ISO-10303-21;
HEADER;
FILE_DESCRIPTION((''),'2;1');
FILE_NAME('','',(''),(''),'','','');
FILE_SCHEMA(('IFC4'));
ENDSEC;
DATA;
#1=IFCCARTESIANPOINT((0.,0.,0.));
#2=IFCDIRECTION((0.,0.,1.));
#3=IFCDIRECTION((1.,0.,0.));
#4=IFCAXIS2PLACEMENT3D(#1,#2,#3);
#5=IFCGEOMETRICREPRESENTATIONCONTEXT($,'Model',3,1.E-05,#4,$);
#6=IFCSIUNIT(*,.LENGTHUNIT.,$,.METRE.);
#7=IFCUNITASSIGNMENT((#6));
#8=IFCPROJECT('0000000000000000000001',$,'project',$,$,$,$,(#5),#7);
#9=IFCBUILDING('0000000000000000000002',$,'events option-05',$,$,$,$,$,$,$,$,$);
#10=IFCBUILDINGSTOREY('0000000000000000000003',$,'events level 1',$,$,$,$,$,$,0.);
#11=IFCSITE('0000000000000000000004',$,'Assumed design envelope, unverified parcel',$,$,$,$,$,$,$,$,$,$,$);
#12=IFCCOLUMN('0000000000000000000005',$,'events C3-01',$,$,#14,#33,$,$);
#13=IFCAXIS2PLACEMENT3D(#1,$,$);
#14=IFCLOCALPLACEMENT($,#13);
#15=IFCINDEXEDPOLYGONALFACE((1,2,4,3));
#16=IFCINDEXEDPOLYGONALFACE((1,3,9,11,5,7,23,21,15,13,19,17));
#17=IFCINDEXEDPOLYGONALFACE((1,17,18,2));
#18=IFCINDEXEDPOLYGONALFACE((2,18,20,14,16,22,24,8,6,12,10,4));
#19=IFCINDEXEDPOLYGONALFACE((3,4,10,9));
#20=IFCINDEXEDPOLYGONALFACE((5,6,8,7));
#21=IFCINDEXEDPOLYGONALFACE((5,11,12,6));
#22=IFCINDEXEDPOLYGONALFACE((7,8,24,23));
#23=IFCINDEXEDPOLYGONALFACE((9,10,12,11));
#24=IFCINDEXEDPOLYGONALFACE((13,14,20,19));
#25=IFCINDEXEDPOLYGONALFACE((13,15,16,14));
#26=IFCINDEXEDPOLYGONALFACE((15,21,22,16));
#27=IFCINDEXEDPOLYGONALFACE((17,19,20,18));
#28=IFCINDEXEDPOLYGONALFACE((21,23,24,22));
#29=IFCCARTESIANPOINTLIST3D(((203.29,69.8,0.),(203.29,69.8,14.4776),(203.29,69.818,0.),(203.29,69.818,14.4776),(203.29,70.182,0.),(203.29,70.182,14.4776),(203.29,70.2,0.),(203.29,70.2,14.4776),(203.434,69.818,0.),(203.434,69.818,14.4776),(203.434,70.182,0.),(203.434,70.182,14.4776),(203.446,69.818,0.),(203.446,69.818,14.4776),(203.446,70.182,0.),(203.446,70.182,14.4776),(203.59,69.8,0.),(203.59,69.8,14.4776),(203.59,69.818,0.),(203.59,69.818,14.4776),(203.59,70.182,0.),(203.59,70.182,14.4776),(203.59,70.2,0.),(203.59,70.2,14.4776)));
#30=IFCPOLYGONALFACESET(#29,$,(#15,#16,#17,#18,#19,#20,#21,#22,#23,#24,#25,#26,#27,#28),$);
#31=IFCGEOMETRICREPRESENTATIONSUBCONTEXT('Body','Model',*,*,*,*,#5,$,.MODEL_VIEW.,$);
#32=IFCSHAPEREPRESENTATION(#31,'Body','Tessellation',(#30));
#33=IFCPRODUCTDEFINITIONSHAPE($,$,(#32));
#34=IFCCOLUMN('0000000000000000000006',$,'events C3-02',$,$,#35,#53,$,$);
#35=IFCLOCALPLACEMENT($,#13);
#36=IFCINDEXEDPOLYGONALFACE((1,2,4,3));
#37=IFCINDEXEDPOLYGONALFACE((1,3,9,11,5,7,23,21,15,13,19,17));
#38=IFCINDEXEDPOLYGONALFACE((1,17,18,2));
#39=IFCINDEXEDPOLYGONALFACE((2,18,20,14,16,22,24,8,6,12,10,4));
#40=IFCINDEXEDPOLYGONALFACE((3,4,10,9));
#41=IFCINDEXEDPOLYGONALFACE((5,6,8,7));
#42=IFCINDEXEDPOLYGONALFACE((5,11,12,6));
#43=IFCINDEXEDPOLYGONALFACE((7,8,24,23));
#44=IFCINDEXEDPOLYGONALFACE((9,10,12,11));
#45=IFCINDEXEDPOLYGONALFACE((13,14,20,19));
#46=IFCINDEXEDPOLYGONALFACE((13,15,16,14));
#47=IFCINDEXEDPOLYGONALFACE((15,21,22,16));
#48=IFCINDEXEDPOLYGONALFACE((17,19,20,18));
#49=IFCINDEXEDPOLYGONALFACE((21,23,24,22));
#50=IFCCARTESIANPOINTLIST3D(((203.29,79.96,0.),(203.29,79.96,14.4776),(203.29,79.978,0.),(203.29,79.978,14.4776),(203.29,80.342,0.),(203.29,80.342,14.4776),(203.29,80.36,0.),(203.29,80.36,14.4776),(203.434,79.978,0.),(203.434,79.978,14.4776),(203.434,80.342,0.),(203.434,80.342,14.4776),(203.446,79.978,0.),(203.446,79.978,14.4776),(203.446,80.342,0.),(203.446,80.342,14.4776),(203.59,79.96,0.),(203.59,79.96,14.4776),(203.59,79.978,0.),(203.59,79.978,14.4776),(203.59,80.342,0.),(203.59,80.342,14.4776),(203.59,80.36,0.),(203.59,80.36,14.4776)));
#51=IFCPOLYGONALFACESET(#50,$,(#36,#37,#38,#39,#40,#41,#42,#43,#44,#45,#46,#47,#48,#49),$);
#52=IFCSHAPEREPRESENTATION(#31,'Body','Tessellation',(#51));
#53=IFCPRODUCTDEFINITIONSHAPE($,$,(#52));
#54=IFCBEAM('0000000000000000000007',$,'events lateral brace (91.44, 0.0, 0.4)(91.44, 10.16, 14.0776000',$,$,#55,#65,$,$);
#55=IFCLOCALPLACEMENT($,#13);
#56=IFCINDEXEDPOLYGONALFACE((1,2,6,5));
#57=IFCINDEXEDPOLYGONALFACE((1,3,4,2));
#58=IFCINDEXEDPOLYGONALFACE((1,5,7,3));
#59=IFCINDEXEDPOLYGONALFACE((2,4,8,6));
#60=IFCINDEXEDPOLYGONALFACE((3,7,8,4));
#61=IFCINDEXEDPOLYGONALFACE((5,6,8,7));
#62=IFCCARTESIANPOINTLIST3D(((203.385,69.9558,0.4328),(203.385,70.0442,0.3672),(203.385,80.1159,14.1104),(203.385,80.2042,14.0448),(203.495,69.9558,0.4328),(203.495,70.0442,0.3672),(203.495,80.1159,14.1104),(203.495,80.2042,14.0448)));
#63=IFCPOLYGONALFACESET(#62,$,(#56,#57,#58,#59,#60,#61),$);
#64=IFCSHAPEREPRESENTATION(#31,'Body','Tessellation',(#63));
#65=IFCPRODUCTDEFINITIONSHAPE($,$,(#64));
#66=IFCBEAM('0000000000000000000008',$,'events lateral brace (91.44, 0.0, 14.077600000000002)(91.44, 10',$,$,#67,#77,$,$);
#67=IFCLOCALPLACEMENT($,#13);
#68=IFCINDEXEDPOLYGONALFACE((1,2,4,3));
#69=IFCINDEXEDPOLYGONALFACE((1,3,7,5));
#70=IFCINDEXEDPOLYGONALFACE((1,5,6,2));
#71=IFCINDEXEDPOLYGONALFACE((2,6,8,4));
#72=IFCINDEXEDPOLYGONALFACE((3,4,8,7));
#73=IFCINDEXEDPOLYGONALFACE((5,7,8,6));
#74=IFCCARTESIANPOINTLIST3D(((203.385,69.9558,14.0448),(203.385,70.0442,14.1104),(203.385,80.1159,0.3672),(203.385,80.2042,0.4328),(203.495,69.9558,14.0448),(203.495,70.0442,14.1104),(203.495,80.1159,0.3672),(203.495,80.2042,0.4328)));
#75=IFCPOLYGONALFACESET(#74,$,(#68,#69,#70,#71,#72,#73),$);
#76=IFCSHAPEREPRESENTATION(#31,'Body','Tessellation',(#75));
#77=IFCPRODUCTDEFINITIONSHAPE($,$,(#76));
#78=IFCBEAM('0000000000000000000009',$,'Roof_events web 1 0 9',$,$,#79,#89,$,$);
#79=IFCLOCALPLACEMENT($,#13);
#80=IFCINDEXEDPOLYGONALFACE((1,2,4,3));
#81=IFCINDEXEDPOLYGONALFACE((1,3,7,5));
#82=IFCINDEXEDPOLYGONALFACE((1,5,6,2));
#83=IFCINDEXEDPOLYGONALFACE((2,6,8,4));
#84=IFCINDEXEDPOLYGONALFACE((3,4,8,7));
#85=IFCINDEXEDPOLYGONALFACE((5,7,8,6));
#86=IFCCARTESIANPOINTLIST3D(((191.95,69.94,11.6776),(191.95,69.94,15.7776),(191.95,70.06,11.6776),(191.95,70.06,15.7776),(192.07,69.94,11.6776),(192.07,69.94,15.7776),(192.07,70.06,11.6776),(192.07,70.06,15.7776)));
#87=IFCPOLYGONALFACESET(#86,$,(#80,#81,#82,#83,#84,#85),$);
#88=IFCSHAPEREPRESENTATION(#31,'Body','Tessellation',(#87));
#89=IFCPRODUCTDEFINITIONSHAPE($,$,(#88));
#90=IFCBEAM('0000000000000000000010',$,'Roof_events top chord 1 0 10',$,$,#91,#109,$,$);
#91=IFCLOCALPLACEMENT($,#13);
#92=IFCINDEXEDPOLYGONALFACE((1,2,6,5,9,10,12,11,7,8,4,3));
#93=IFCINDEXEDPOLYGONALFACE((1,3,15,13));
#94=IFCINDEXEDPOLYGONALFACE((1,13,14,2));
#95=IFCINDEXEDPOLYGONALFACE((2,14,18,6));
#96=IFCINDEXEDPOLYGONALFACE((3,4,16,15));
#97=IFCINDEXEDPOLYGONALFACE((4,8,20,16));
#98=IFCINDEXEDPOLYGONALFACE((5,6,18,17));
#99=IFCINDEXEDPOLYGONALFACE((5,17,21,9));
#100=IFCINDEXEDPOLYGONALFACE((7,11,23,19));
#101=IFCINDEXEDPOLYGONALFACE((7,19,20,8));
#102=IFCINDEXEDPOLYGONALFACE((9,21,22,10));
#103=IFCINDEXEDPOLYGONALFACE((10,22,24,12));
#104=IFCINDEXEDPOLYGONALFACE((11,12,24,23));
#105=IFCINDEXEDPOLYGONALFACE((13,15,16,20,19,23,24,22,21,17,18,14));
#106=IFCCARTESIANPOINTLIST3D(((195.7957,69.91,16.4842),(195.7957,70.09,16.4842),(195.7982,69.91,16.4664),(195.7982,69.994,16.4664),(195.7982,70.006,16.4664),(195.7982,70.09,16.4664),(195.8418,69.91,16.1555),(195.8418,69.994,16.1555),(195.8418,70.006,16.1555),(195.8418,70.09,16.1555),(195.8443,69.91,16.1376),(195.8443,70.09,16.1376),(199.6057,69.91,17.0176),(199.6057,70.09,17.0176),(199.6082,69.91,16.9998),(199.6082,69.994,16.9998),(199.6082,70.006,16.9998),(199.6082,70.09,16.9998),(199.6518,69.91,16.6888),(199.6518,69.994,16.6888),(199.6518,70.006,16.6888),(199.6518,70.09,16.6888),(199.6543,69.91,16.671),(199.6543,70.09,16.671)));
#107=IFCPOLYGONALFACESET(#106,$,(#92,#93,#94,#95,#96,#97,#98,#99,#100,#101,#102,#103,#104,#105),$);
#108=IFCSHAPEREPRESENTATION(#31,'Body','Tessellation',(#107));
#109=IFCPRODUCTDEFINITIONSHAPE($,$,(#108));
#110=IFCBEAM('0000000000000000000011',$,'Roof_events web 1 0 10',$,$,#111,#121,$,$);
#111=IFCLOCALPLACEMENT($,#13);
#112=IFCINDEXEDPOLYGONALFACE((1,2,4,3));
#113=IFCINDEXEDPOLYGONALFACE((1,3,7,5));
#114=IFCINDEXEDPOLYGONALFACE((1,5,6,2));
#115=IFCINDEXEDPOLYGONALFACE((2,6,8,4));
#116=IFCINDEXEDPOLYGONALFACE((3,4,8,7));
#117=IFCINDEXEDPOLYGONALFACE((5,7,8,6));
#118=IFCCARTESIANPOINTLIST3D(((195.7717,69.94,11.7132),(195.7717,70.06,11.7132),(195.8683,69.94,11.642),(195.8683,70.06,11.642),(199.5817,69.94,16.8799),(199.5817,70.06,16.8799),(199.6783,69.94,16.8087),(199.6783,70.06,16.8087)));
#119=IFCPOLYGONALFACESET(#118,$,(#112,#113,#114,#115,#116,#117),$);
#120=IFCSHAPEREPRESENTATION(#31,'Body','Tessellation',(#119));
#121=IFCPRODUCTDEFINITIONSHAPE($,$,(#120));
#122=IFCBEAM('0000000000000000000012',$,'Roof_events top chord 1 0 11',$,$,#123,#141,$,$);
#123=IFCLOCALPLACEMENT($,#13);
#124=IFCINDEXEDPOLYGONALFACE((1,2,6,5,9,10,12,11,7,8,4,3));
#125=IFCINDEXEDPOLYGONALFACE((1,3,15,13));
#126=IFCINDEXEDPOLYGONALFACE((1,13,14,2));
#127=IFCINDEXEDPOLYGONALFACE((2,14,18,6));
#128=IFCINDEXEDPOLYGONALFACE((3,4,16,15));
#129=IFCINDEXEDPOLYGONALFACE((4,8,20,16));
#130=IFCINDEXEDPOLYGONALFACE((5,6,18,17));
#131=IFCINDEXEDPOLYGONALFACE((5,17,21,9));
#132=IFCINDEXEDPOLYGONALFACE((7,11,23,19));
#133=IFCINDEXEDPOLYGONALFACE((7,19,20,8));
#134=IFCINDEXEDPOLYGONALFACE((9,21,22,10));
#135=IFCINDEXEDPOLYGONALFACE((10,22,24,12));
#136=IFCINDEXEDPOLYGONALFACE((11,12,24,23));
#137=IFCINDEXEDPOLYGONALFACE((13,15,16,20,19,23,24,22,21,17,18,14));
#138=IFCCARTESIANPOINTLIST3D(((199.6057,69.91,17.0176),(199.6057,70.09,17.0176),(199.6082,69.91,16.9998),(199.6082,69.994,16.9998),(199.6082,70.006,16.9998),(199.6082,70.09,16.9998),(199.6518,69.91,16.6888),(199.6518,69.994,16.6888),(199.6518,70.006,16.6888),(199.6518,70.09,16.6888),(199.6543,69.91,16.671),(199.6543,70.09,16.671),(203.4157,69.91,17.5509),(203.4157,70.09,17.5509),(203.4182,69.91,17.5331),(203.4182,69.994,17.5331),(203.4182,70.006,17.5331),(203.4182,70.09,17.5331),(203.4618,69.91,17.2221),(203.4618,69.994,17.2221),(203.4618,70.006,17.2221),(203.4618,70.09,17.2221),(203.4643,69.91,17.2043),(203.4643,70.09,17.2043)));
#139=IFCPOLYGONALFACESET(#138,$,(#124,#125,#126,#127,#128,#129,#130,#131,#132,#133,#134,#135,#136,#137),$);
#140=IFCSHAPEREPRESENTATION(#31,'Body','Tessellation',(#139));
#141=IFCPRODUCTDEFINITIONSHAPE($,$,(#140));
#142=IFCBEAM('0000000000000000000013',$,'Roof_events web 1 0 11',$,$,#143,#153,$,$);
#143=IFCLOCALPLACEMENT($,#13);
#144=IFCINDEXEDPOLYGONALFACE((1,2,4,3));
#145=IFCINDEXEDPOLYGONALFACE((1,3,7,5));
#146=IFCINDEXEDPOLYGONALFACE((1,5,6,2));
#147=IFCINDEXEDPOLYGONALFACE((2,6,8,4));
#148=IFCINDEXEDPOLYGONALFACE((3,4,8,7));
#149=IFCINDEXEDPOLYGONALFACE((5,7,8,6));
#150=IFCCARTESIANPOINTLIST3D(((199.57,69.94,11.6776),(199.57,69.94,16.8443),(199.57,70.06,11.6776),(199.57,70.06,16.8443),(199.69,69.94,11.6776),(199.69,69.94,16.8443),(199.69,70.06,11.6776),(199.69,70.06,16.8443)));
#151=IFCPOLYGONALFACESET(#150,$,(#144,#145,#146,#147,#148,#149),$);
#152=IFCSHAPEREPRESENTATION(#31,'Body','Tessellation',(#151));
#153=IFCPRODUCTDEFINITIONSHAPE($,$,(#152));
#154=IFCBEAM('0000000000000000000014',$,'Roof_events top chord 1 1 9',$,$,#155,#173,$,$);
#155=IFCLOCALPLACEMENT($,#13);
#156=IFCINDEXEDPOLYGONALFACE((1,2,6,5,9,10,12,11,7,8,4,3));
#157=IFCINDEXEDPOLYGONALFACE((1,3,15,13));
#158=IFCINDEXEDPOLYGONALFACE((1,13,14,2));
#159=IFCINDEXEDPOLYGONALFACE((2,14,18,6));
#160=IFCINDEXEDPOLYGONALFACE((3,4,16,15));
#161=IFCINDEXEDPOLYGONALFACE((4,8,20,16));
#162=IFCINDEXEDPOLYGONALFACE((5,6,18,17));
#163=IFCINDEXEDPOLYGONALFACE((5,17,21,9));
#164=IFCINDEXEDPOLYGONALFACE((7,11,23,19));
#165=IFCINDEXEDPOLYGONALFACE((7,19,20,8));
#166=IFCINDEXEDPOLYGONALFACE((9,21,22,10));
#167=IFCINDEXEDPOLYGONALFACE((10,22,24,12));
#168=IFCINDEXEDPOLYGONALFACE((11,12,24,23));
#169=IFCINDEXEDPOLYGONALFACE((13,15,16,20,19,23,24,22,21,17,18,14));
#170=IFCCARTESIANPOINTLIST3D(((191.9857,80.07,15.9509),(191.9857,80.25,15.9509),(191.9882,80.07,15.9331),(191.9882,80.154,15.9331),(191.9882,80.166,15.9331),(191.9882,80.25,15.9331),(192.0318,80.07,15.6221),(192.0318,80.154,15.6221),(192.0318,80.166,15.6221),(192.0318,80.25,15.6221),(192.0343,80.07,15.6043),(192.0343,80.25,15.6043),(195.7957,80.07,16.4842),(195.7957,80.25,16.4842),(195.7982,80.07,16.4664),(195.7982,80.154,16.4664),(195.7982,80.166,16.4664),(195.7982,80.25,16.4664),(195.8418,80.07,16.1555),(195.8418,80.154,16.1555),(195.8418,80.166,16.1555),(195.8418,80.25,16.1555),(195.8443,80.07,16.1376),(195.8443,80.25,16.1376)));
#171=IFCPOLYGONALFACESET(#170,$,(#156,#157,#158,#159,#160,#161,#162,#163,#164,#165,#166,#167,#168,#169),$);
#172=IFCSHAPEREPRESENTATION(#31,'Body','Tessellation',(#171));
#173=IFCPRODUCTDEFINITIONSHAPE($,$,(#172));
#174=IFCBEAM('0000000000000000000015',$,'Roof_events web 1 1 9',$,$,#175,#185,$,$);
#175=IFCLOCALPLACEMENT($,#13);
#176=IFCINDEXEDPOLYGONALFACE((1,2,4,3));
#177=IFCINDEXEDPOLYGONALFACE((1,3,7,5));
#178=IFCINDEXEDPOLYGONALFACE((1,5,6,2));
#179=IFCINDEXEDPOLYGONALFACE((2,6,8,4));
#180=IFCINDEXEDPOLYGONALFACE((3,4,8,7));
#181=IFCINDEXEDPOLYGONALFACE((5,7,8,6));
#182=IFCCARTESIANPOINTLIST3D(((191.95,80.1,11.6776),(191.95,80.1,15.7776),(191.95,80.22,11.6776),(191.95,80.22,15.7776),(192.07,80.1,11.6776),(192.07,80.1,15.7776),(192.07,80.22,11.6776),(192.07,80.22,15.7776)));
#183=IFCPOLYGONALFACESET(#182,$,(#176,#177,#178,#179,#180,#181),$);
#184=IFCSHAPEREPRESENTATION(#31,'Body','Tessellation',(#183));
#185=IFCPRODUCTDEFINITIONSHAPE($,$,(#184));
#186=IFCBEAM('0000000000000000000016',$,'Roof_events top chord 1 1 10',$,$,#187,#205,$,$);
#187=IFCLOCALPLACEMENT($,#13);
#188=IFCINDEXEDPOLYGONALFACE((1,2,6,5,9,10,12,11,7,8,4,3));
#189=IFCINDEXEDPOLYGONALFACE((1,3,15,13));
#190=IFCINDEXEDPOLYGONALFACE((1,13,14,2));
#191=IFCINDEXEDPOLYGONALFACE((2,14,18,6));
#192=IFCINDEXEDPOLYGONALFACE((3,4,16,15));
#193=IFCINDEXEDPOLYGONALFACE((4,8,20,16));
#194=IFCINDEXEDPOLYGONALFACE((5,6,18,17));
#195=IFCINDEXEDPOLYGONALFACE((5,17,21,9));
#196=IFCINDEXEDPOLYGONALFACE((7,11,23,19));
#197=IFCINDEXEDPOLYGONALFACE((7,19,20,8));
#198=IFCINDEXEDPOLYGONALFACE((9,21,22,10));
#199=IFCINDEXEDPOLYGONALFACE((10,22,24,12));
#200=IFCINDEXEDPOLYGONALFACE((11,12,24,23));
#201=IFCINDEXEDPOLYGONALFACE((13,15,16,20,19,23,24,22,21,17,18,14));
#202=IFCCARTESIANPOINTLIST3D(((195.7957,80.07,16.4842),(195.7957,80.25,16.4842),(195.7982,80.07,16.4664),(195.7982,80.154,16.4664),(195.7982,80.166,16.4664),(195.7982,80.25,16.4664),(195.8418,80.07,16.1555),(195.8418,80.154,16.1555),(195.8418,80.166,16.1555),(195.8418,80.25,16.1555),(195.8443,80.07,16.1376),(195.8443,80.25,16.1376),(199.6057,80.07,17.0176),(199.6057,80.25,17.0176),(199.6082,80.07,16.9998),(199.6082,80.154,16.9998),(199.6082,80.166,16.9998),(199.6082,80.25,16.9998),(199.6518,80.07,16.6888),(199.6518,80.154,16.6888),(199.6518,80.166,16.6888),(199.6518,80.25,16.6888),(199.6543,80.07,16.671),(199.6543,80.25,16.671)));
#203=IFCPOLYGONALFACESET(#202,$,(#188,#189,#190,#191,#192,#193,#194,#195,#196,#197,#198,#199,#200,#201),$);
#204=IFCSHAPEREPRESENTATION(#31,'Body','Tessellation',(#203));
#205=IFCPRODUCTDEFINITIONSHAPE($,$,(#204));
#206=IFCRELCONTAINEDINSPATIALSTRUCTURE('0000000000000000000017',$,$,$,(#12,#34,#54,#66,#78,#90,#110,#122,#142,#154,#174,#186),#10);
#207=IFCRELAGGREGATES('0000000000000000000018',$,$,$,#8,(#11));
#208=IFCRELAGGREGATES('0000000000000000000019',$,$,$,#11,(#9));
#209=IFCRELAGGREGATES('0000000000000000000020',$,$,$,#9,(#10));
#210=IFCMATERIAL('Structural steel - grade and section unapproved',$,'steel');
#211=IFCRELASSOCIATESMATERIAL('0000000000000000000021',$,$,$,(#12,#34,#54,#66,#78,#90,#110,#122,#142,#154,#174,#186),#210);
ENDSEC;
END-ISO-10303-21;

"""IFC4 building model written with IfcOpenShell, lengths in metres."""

from ifc_helpers import new_model, si_unit, frame, origin_with_axes, place, context, subcontext, project, spatial, rectangle, i_section, extrude, material, element, save


model = new_model("IFC4")

# Units and contexts
model_context = context("Model", 3, precision=1e-05, world=origin_with_axes())
body_context = subcontext(model_context, "Body", "Model", "MODEL_VIEW")
ifc_project = project(units=[si_unit("LENGTHUNIT", "METRE")], contexts=[model_context])

# Site, building, storey
site = spatial("IfcSite", under=ifc_project, Name="Assumed design envelope, unverified parcel")
building = spatial("IfcBuilding", under=site, Name="events option-05")
storey = spatial("IfcBuildingStorey", under=building, Name="events level 1", Elevation=0.0)

# Columns
ifc_material_1 = material(Name="Structural steel - grade and section unapproved", Category="steel")
for number, where, z_axis, x_axis, name in (
    (1, (203.44, 70.0, 0.0), (0.0, 0.0, 1.0), (-1.0, 0.0, 0.0), "events C3-01"),
    (2, (203.44, 80.16, 0.0), (0.0, 0.0, 1.0), (-1.0, 0.0, 0.0), "events C3-02"),
):
    element("IfcColumn", number, at=place(None, frame(where, z_axis=z_axis, x_axis=x_axis)), inside=storey, material=ifc_material_1, Name=name, context=body_context, shape_type="SweptSolid", body=[
        extrude(i_section(OverallWidth=0.3, OverallDepth=0.4, WebThickness=0.012, FlangeThickness=0.018, FilletRadius=0.0), origin_with_axes(), (0.0, 0.0, 1.0), 14.4776),
    ])

# Beams
for number, where, z_axis, x_axis, name in (
    (3, (203.44, 70.0, 0.4), (0.0, 0.596305, 0.802758), (-1.0, 0.0, 0.0), "events lateral brace (91.44, 0.0, 0.4)(91.44, 10.16, 14.0776000"),
    (4, (203.44, 70.0, 14.0776), (0.0, 0.596305, -0.802758), (-1.0, 0.0, 0.0), "events lateral brace (91.44, 0.0, 14.077600000000002)(91.44, 10"),
):
    element("IfcBeam", number, at=place(None, frame(where, z_axis=z_axis, x_axis=x_axis)), inside=storey, material=ifc_material_1, Name=name, context=body_context, shape_type="SweptSolid", body=[
        extrude(rectangle(XDim=0.11, YDim=0.11), origin_with_axes(), (0.0, 0.0, 1.0), 17.0383),
    ])
beam_1_placement = place(None, frame((192.01, 70.0, 11.6776), z_axis=(0.0, 0.0, 1.0), x_axis=(-1.0, 0.0, 0.0)))
element("IfcBeam", 5, at=beam_1_placement, inside=storey, material=ifc_material_1, Name="Roof_events web 1 0 9", context=body_context, shape_type="SweptSolid", body=[
    extrude(rectangle(XDim=0.12, YDim=0.12), origin_with_axes(), (0.0, 0.0, 1.0), 4.1),
])
beam_2_placement = place(None, frame((195.82, 70.0, 16.3109), z_axis=(0.990344, 0.0, 0.138631), x_axis=(0.0, 1.0, 0.0)))
element("IfcBeam", 6, at=beam_2_placement, inside=storey, material=ifc_material_1, Name="Roof_events top chord 1 0 10", context=body_context, shape_type="SweptSolid", body=[
    extrude(i_section(OverallWidth=0.18, OverallDepth=0.35, WebThickness=0.012, FlangeThickness=0.018, FilletRadius=0.0), origin_with_axes(), (0.0, 0.0, 1.0), 3.8471),
])
beam_3_placement = place(None, frame((195.82, 70.0, 11.6776), z_axis=(0.5935, 0.0, 0.804834), x_axis=(0.0, 1.0, 0.0)))
element("IfcBeam", 7, at=beam_3_placement, inside=storey, material=ifc_material_1, Name="Roof_events web 1 0 10", context=body_context, shape_type="SweptSolid", body=[
    extrude(rectangle(XDim=0.12, YDim=0.12), origin_with_axes(), (0.0, 0.0, 1.0), 6.4195),
])
beam_4_placement = place(None, frame((199.63, 70.0, 16.8443), z_axis=(0.990344, 0.0, 0.138631), x_axis=(0.0, 1.0, 0.0)))
element("IfcBeam", 8, at=beam_4_placement, inside=storey, material=ifc_material_1, Name="Roof_events top chord 1 0 11", context=body_context, shape_type="SweptSolid", body=[
    extrude(i_section(OverallWidth=0.18, OverallDepth=0.35, WebThickness=0.012, FlangeThickness=0.018, FilletRadius=0.0), origin_with_axes(), (0.0, 0.0, 1.0), 3.8471),
])
beam_5_placement = place(None, frame((199.63, 70.0, 11.6776), z_axis=(0.0, 0.0, 1.0), x_axis=(-1.0, 0.0, 0.0)))
element("IfcBeam", 9, at=beam_5_placement, inside=storey, material=ifc_material_1, Name="Roof_events web 1 0 11", context=body_context, shape_type="SweptSolid", body=[
    extrude(rectangle(XDim=0.12, YDim=0.12), origin_with_axes(), (0.0, 0.0, 1.0), 5.1667),
])
beam_6_placement = place(None, frame((192.01, 80.16, 15.7776), z_axis=(0.990344, 0.0, 0.138631), x_axis=(0.0, 1.0, 0.0)))
element("IfcBeam", 10, at=beam_6_placement, inside=storey, material=ifc_material_1, Name="Roof_events top chord 1 1 9", context=body_context, shape_type="SweptSolid", body=[
    extrude(i_section(OverallWidth=0.18, OverallDepth=0.35, WebThickness=0.012, FlangeThickness=0.018, FilletRadius=0.0), origin_with_axes(), (0.0, 0.0, 1.0), 3.8472),
])
beam_7_placement = place(None, frame((192.01, 80.16, 11.6776), z_axis=(0.0, 0.0, 1.0), x_axis=(-1.0, 0.0, 0.0)))
element("IfcBeam", 11, at=beam_7_placement, inside=storey, material=ifc_material_1, Name="Roof_events web 1 1 9", context=body_context, shape_type="SweptSolid", body=[
    extrude(rectangle(XDim=0.12, YDim=0.12), origin_with_axes(), (0.0, 0.0, 1.0), 4.1),
])
beam_8_placement = place(None, frame((195.82, 80.16, 16.3109), z_axis=(0.990344, 0.0, 0.138631), x_axis=(0.0, 1.0, 0.0)))
element("IfcBeam", 12, at=beam_8_placement, inside=storey, material=ifc_material_1, Name="Roof_events top chord 1 1 10", context=body_context, shape_type="SweptSolid", body=[
    extrude(i_section(OverallWidth=0.18, OverallDepth=0.35, WebThickness=0.012, FlangeThickness=0.018, FilletRadius=0.0), origin_with_axes(), (0.0, 0.0, 1.0), 3.8471),
])

save(model, "model.ifc")
